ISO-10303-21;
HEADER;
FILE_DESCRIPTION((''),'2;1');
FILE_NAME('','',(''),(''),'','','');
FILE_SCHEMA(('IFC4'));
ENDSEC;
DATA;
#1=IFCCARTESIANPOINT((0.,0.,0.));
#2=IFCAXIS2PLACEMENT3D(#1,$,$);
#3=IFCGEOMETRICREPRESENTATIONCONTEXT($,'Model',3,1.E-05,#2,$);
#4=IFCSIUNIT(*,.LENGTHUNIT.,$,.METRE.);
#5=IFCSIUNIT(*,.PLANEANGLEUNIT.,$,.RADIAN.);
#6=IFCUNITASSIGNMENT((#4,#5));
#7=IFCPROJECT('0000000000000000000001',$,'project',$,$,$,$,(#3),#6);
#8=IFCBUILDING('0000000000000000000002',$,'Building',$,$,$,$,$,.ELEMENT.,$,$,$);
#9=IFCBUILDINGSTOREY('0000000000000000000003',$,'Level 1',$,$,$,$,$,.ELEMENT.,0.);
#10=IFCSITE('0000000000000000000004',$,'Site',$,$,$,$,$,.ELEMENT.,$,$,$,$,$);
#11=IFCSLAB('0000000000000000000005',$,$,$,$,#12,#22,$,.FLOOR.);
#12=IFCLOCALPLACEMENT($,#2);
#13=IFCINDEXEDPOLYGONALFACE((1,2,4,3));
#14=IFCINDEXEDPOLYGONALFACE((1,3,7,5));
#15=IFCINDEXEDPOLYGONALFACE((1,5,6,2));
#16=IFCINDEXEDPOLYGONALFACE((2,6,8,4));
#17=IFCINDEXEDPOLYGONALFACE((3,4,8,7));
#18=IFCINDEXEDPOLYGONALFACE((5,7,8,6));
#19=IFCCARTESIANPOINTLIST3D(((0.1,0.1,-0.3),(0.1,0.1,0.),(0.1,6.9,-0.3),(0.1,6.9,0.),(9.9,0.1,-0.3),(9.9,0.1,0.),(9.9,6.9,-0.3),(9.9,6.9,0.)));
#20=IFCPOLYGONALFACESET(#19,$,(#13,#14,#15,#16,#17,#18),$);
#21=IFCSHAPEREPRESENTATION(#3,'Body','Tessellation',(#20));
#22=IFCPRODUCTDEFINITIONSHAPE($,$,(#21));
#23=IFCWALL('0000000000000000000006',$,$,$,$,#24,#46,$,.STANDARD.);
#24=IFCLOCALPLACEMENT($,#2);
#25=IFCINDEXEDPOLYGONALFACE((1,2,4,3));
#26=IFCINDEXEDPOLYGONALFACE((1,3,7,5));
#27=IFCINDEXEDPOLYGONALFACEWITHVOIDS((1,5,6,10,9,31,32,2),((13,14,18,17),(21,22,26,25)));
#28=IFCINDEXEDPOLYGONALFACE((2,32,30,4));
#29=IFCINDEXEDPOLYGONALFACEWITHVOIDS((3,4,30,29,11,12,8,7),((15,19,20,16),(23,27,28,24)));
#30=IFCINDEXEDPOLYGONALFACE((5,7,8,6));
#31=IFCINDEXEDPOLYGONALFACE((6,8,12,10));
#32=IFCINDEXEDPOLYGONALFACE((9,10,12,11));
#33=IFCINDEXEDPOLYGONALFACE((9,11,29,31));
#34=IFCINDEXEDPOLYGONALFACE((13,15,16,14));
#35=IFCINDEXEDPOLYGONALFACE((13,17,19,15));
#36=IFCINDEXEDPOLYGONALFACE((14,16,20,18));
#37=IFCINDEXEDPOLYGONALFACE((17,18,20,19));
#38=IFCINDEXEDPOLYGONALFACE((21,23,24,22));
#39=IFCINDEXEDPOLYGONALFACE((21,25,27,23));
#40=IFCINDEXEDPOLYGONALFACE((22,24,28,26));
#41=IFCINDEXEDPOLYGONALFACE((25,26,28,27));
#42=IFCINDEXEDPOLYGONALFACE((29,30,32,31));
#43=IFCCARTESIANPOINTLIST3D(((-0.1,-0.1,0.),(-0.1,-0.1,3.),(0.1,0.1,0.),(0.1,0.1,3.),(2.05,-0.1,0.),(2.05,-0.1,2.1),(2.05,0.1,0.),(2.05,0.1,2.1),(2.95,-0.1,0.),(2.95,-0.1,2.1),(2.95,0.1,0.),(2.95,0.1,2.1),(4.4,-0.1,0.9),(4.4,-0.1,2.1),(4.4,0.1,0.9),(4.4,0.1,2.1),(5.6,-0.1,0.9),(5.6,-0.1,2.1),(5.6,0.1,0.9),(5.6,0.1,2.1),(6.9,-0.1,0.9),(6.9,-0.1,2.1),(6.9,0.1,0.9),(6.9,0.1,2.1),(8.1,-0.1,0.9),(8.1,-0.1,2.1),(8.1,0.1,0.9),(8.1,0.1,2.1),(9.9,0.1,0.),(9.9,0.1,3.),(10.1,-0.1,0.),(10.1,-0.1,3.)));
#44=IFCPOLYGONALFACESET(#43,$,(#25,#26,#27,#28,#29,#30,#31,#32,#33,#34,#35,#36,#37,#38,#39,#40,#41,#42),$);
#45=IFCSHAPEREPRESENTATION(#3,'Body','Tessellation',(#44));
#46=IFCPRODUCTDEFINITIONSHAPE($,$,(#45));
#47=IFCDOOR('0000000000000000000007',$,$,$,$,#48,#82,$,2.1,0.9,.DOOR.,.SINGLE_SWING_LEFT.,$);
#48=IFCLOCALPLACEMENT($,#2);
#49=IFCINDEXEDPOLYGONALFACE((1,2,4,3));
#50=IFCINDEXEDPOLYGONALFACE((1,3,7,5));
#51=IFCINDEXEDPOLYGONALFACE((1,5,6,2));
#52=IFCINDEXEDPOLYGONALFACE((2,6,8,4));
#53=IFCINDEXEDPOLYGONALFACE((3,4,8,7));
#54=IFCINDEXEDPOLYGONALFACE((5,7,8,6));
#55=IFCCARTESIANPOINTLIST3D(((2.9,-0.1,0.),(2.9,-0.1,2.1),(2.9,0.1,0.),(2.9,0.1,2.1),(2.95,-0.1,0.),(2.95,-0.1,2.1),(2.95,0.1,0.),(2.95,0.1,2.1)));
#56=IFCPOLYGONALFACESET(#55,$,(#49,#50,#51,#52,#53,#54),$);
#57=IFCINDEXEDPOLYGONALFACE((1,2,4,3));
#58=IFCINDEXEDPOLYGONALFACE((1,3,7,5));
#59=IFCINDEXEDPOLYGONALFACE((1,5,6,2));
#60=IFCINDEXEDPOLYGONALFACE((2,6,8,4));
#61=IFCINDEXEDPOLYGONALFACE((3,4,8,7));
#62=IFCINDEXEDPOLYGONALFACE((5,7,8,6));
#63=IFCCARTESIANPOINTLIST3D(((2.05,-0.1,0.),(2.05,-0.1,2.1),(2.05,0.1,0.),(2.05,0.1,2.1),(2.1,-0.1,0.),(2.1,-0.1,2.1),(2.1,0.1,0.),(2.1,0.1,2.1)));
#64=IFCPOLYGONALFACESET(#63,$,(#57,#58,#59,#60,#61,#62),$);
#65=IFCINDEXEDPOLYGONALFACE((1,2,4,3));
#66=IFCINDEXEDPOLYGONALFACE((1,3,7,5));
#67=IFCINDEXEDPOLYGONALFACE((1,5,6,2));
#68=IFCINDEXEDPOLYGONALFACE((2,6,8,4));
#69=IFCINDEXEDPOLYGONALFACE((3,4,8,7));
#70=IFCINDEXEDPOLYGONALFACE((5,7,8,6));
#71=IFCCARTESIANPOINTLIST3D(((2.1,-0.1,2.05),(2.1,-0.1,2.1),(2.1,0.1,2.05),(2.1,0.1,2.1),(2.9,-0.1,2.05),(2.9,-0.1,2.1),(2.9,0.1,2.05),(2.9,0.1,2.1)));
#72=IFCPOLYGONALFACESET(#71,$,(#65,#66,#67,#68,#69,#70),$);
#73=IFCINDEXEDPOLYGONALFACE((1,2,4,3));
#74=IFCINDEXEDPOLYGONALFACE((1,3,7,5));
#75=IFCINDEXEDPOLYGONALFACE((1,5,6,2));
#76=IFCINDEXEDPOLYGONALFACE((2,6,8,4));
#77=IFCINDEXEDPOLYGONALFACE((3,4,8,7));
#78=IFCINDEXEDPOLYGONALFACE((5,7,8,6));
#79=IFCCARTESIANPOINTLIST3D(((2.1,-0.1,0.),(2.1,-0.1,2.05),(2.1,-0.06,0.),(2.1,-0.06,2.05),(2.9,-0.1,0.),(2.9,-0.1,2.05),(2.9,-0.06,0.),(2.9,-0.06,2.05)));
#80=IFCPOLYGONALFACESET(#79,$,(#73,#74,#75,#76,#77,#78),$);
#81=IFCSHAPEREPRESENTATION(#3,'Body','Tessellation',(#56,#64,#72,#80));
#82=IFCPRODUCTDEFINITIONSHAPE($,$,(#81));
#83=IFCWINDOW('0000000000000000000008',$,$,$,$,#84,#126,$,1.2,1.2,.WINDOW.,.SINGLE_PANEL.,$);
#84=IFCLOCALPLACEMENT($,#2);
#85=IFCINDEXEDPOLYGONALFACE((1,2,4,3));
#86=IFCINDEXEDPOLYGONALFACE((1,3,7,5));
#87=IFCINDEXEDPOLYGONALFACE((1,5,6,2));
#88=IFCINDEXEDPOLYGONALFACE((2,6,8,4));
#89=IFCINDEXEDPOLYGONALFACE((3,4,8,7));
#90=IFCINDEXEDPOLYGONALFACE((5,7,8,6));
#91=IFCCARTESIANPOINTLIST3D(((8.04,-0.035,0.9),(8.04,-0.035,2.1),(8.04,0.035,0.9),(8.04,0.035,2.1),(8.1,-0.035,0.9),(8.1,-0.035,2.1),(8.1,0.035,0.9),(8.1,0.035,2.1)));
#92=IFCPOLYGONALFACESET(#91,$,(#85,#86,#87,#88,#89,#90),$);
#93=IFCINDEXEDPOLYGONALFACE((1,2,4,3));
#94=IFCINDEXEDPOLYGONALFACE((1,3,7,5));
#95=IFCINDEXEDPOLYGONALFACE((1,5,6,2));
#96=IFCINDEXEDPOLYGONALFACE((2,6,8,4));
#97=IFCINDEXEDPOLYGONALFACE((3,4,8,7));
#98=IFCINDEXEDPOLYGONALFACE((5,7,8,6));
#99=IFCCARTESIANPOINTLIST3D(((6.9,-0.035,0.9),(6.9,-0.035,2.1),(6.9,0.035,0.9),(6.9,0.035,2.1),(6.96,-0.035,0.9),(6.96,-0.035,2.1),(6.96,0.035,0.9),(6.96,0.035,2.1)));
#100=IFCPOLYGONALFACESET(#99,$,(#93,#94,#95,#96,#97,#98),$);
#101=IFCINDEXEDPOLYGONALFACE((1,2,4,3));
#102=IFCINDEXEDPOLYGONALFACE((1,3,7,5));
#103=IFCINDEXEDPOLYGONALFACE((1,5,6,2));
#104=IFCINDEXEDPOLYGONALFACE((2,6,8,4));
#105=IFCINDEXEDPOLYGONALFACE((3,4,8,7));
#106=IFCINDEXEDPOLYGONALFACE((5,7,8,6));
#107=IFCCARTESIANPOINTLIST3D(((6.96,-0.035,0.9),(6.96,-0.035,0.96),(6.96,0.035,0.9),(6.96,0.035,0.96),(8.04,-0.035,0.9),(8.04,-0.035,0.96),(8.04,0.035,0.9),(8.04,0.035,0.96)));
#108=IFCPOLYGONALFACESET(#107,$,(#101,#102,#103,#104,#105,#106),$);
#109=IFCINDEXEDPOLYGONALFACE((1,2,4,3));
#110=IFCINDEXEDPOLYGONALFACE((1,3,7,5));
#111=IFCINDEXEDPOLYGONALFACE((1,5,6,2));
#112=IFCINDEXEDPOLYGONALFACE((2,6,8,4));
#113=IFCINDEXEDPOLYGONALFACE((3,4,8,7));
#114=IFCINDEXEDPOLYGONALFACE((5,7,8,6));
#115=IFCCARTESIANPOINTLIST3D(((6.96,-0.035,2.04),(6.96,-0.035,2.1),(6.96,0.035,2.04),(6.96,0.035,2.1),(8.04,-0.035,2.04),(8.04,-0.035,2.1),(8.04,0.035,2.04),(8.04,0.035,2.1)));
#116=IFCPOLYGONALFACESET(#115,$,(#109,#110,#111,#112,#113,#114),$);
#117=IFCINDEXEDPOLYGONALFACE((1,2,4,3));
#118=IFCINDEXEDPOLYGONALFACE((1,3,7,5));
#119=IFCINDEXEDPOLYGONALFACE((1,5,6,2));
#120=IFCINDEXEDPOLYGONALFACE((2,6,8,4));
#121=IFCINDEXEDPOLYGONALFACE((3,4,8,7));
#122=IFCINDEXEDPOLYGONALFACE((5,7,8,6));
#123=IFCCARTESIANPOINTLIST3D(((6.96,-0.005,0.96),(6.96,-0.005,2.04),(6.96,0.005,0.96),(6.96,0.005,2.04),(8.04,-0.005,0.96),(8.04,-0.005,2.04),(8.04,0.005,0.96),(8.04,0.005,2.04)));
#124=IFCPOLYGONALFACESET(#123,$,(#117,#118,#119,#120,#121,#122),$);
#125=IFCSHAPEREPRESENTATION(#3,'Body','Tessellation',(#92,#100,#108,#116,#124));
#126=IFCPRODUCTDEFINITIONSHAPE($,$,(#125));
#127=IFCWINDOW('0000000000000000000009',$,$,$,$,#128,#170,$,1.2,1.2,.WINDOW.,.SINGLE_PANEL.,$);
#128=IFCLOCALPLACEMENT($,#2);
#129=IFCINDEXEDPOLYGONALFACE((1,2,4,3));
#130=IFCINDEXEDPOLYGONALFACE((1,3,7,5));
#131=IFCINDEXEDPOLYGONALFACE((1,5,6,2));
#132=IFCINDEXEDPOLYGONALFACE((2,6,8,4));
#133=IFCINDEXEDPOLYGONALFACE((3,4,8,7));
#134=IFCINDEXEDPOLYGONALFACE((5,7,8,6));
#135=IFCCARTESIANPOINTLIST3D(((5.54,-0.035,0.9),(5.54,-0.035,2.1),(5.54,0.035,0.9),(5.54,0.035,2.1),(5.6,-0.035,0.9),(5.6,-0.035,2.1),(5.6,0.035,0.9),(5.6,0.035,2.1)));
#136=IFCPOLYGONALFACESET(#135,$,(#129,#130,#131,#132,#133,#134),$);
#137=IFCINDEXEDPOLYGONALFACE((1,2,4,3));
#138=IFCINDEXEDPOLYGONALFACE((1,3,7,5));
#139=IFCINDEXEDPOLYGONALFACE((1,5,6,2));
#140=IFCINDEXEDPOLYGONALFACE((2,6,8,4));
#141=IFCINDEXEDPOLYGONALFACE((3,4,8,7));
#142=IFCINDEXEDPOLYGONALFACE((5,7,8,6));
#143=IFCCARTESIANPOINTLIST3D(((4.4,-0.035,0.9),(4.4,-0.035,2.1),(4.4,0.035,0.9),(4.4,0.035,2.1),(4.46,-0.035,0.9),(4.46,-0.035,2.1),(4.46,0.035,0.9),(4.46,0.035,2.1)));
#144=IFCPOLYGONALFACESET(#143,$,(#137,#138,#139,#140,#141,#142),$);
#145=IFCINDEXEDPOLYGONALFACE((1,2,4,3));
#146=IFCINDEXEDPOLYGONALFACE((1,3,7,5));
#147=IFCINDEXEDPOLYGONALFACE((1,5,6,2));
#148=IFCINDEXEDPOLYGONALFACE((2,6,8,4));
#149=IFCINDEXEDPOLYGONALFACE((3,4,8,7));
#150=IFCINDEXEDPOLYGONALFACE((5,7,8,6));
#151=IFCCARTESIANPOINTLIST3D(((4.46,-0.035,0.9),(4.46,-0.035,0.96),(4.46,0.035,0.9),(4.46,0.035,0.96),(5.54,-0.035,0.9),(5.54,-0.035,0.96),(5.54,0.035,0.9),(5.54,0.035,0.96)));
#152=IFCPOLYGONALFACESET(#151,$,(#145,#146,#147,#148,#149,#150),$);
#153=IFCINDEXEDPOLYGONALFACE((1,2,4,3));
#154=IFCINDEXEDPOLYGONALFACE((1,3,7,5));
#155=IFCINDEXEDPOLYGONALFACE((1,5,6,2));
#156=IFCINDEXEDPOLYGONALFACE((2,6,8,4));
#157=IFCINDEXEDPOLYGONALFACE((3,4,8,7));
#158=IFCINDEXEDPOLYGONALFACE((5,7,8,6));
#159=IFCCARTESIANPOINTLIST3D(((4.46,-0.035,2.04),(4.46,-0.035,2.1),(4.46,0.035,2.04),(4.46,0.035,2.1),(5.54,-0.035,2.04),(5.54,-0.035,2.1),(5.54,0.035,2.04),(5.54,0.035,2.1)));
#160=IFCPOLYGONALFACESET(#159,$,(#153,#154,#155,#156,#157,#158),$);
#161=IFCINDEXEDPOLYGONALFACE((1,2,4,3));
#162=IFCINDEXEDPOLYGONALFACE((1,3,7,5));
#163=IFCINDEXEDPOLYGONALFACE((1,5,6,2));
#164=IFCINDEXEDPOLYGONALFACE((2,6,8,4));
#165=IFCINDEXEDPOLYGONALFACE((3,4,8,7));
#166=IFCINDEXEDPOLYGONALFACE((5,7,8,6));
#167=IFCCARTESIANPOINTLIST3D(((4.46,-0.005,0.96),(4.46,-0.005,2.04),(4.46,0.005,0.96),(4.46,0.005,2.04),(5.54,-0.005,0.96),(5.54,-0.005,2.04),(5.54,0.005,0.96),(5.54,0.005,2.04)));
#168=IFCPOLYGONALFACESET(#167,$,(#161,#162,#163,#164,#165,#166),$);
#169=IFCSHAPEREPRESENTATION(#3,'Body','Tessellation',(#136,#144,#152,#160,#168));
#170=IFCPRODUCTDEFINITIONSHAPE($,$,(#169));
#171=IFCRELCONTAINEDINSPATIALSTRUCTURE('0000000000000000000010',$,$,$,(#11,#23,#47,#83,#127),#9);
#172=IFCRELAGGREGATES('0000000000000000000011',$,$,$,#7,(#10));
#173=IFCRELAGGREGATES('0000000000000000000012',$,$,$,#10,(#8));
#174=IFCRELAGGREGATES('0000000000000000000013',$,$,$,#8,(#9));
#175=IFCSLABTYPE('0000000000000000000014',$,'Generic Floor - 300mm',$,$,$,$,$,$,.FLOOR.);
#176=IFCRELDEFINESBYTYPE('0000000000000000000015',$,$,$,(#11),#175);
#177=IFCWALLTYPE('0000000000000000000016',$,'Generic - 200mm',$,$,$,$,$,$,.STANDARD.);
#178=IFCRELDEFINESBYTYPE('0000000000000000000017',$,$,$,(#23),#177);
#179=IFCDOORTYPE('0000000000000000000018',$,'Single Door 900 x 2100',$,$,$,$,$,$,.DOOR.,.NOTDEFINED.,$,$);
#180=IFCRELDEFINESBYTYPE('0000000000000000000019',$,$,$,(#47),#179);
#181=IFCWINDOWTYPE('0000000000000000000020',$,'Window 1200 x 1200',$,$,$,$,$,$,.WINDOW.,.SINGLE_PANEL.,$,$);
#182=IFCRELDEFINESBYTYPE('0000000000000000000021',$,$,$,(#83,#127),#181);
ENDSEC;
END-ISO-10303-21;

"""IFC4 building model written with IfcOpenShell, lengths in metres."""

from ifc_helpers import new_model, si_unit, frame, frame_2d, origin, origin_with_axes, origin_2d, place, context, project, spatial, polyline, rectangle, outline, extrude, type_object, element, fill, save


model = new_model("IFC4")

# Units and contexts
model_context = context("Model", 3, precision=1e-05, world=origin())
ifc_project = project(units=[si_unit("LENGTHUNIT", "METRE"), si_unit("PLANEANGLEUNIT", "RADIAN")], contexts=[model_context])

# Site, building, storey
site = spatial("IfcSite", under=ifc_project, Name="Site", CompositionType="ELEMENT")
building = spatial("IfcBuilding", under=site, Name="Building", CompositionType="ELEMENT")
storey = spatial("IfcBuildingStorey", under=building, Name="Level 1", CompositionType="ELEMENT", Elevation=0.0)

# Slab
slab_type = type_object("IfcSlabType", Name="Generic Floor - 300mm", PredefinedType="FLOOR")
slab_placement = place(None, origin())
element("IfcSlab", 1, at=slab_placement, inside=storey, type_object=slab_type, PredefinedType="FLOOR", context=model_context, shape_type="SweptSolid", body=[
    extrude(outline(polyline([(0.1, 0.1), (9.9, 0.1), (9.9, 6.9), (0.1, 6.9), (0.1, 0.1)])), origin(), (0.0, 0.0, -1.0), 0.3),
])

# Wall, openings, door, windows
wall_type = type_object("IfcWallType", Name="Generic - 200mm", PredefinedType="STANDARD")
wall_1_placement = place(None, frame((10.0, 0.0, 0.0), z_axis=(0.0, 0.0, 1.0), x_axis=(-1.0, 0.0, 0.0)))
wall_1 = element("IfcWall", 2, at=wall_1_placement, inside=storey, type_object=wall_type, PredefinedType="STANDARD", context=model_context, shape_type="SweptSolid", body=[
    extrude(outline(polyline([(0.1, -0.1), (9.9, -0.1), (10.1, 0.1), (-0.1, 0.1), (0.1, -0.1)])), origin(), (0.0, 0.0, 1.0), 3.0),
])
opening_1_placement = place(wall_1_placement, frame((7.5, 0.0, 0.0), z_axis=(0.0, 0.0, 1.0), x_axis=(1.0, 0.0, 0.0)))
opening_1 = element("IfcOpeningElement", 3, at=opening_1_placement, cuts=wall_1, PredefinedType="OPENING", context=model_context, shape_type="SweptSolid", body=[
    extrude(rectangle(XDim=0.9, YDim=0.202, at=origin_2d()), origin(), (0.0, 0.0, 1.0), 2.1),
])
opening_2_placement = place(wall_1_placement, frame((2.5, 0.0, 0.9), z_axis=(0.0, 0.0, 1.0), x_axis=(1.0, 0.0, 0.0)))
opening_2 = element("IfcOpeningElement", 4, at=opening_2_placement, cuts=wall_1, PredefinedType="OPENING", context=model_context, shape_type="SweptSolid", body=[
    extrude(rectangle(XDim=1.2, YDim=0.202, at=origin_2d()), origin(), (0.0, 0.0, 1.0), 1.2),
])
opening_3_placement = place(wall_1_placement, frame((5.0, 0.0, 0.9), z_axis=(0.0, 0.0, 1.0), x_axis=(1.0, 0.0, 0.0)))
opening_3 = element("IfcOpeningElement", 5, at=opening_3_placement, cuts=wall_1, PredefinedType="OPENING", context=model_context, shape_type="SweptSolid", body=[
    extrude(rectangle(XDim=1.2, YDim=0.202, at=origin_2d()), origin(), (0.0, 0.0, 1.0), 1.2),
])
door_type = type_object("IfcDoorType", Name="Single Door 900 x 2100", OperationType="NOTDEFINED", PredefinedType="DOOR")
door_1_placement = place(opening_1_placement, origin_with_axes())
door_1 = element("IfcDoor", 6, at=door_1_placement, inside=storey, type_object=door_type, OperationType="SINGLE_SWING_LEFT", OverallHeight=2.1, OverallWidth=0.9, PredefinedType="DOOR", context=model_context, shape_type="SweptSolid", body=[
    extrude(rectangle(XDim=0.05, YDim=0.2, at=frame_2d((-0.425, 0.0))), origin(), (0.0, 0.0, 1.0), 2.1),
    extrude(rectangle(XDim=0.05, YDim=0.2, at=frame_2d((0.425, 0.0))), origin(), (0.0, 0.0, 1.0), 2.1),
    extrude(rectangle(XDim=0.8, YDim=0.2, at=origin_2d()), frame((0.0, 0.0, 2.05)), (0.0, 0.0, 1.0), 0.05),
    extrude(rectangle(XDim=0.8, YDim=0.04, at=frame_2d((0.0, 0.08))), origin(), (0.0, 0.0, 1.0), 2.05),
])
fill(opening_1, door_1)
window_type = type_object("IfcWindowType", Name="Window 1200 x 1200", PartitioningType="SINGLE_PANEL", PredefinedType="WINDOW")
window_1_placement = place(opening_2_placement, origin_with_axes())
window_1 = element("IfcWindow", 7, at=window_1_placement, inside=storey, type_object=window_type, OverallHeight=1.2, OverallWidth=1.2, PartitioningType="SINGLE_PANEL", PredefinedType="WINDOW", context=model_context, shape_type="SweptSolid", body=[
    extrude(rectangle(XDim=0.06, YDim=0.07, at=frame_2d((-0.57, 0.0))), origin(), (0.0, 0.0, 1.0), 1.2),
    extrude(rectangle(XDim=0.06, YDim=0.07, at=frame_2d((0.57, 0.0))), origin(), (0.0, 0.0, 1.0), 1.2),
    extrude(rectangle(XDim=1.08, YDim=0.07, at=origin_2d()), origin(), (0.0, 0.0, 1.0), 0.06),
    extrude(rectangle(XDim=1.08, YDim=0.07, at=origin_2d()), frame((0.0, 0.0, 1.14)), (0.0, 0.0, 1.0), 0.06),
    extrude(rectangle(XDim=1.08, YDim=0.01, at=origin_2d()), frame((0.0, 0.0, 0.06)), (0.0, 0.0, 1.0), 1.08),
])
fill(opening_2, window_1)
window_2_placement = place(opening_3_placement, origin_with_axes())
window_2 = element("IfcWindow", 8, at=window_2_placement, inside=storey, type_object=window_type, OverallHeight=1.2, OverallWidth=1.2, PartitioningType="SINGLE_PANEL", PredefinedType="WINDOW", context=model_context, shape_type="SweptSolid", body=[
    extrude(rectangle(XDim=0.06, YDim=0.07, at=frame_2d((-0.57, 0.0))), origin(), (0.0, 0.0, 1.0), 1.2),
    extrude(rectangle(XDim=0.06, YDim=0.07, at=frame_2d((0.57, 0.0))), origin(), (0.0, 0.0, 1.0), 1.2),
    extrude(rectangle(XDim=1.08, YDim=0.07, at=origin_2d()), origin(), (0.0, 0.0, 1.0), 0.06),
    extrude(rectangle(XDim=1.08, YDim=0.07, at=origin_2d()), frame((0.0, 0.0, 1.14)), (0.0, 0.0, 1.0), 0.06),
    extrude(rectangle(XDim=1.08, YDim=0.01, at=origin_2d()), frame((0.0, 0.0, 0.06)), (0.0, 0.0, 1.0), 1.08),
])
fill(opening_3, window_2)

save(model, "model.ifc")
